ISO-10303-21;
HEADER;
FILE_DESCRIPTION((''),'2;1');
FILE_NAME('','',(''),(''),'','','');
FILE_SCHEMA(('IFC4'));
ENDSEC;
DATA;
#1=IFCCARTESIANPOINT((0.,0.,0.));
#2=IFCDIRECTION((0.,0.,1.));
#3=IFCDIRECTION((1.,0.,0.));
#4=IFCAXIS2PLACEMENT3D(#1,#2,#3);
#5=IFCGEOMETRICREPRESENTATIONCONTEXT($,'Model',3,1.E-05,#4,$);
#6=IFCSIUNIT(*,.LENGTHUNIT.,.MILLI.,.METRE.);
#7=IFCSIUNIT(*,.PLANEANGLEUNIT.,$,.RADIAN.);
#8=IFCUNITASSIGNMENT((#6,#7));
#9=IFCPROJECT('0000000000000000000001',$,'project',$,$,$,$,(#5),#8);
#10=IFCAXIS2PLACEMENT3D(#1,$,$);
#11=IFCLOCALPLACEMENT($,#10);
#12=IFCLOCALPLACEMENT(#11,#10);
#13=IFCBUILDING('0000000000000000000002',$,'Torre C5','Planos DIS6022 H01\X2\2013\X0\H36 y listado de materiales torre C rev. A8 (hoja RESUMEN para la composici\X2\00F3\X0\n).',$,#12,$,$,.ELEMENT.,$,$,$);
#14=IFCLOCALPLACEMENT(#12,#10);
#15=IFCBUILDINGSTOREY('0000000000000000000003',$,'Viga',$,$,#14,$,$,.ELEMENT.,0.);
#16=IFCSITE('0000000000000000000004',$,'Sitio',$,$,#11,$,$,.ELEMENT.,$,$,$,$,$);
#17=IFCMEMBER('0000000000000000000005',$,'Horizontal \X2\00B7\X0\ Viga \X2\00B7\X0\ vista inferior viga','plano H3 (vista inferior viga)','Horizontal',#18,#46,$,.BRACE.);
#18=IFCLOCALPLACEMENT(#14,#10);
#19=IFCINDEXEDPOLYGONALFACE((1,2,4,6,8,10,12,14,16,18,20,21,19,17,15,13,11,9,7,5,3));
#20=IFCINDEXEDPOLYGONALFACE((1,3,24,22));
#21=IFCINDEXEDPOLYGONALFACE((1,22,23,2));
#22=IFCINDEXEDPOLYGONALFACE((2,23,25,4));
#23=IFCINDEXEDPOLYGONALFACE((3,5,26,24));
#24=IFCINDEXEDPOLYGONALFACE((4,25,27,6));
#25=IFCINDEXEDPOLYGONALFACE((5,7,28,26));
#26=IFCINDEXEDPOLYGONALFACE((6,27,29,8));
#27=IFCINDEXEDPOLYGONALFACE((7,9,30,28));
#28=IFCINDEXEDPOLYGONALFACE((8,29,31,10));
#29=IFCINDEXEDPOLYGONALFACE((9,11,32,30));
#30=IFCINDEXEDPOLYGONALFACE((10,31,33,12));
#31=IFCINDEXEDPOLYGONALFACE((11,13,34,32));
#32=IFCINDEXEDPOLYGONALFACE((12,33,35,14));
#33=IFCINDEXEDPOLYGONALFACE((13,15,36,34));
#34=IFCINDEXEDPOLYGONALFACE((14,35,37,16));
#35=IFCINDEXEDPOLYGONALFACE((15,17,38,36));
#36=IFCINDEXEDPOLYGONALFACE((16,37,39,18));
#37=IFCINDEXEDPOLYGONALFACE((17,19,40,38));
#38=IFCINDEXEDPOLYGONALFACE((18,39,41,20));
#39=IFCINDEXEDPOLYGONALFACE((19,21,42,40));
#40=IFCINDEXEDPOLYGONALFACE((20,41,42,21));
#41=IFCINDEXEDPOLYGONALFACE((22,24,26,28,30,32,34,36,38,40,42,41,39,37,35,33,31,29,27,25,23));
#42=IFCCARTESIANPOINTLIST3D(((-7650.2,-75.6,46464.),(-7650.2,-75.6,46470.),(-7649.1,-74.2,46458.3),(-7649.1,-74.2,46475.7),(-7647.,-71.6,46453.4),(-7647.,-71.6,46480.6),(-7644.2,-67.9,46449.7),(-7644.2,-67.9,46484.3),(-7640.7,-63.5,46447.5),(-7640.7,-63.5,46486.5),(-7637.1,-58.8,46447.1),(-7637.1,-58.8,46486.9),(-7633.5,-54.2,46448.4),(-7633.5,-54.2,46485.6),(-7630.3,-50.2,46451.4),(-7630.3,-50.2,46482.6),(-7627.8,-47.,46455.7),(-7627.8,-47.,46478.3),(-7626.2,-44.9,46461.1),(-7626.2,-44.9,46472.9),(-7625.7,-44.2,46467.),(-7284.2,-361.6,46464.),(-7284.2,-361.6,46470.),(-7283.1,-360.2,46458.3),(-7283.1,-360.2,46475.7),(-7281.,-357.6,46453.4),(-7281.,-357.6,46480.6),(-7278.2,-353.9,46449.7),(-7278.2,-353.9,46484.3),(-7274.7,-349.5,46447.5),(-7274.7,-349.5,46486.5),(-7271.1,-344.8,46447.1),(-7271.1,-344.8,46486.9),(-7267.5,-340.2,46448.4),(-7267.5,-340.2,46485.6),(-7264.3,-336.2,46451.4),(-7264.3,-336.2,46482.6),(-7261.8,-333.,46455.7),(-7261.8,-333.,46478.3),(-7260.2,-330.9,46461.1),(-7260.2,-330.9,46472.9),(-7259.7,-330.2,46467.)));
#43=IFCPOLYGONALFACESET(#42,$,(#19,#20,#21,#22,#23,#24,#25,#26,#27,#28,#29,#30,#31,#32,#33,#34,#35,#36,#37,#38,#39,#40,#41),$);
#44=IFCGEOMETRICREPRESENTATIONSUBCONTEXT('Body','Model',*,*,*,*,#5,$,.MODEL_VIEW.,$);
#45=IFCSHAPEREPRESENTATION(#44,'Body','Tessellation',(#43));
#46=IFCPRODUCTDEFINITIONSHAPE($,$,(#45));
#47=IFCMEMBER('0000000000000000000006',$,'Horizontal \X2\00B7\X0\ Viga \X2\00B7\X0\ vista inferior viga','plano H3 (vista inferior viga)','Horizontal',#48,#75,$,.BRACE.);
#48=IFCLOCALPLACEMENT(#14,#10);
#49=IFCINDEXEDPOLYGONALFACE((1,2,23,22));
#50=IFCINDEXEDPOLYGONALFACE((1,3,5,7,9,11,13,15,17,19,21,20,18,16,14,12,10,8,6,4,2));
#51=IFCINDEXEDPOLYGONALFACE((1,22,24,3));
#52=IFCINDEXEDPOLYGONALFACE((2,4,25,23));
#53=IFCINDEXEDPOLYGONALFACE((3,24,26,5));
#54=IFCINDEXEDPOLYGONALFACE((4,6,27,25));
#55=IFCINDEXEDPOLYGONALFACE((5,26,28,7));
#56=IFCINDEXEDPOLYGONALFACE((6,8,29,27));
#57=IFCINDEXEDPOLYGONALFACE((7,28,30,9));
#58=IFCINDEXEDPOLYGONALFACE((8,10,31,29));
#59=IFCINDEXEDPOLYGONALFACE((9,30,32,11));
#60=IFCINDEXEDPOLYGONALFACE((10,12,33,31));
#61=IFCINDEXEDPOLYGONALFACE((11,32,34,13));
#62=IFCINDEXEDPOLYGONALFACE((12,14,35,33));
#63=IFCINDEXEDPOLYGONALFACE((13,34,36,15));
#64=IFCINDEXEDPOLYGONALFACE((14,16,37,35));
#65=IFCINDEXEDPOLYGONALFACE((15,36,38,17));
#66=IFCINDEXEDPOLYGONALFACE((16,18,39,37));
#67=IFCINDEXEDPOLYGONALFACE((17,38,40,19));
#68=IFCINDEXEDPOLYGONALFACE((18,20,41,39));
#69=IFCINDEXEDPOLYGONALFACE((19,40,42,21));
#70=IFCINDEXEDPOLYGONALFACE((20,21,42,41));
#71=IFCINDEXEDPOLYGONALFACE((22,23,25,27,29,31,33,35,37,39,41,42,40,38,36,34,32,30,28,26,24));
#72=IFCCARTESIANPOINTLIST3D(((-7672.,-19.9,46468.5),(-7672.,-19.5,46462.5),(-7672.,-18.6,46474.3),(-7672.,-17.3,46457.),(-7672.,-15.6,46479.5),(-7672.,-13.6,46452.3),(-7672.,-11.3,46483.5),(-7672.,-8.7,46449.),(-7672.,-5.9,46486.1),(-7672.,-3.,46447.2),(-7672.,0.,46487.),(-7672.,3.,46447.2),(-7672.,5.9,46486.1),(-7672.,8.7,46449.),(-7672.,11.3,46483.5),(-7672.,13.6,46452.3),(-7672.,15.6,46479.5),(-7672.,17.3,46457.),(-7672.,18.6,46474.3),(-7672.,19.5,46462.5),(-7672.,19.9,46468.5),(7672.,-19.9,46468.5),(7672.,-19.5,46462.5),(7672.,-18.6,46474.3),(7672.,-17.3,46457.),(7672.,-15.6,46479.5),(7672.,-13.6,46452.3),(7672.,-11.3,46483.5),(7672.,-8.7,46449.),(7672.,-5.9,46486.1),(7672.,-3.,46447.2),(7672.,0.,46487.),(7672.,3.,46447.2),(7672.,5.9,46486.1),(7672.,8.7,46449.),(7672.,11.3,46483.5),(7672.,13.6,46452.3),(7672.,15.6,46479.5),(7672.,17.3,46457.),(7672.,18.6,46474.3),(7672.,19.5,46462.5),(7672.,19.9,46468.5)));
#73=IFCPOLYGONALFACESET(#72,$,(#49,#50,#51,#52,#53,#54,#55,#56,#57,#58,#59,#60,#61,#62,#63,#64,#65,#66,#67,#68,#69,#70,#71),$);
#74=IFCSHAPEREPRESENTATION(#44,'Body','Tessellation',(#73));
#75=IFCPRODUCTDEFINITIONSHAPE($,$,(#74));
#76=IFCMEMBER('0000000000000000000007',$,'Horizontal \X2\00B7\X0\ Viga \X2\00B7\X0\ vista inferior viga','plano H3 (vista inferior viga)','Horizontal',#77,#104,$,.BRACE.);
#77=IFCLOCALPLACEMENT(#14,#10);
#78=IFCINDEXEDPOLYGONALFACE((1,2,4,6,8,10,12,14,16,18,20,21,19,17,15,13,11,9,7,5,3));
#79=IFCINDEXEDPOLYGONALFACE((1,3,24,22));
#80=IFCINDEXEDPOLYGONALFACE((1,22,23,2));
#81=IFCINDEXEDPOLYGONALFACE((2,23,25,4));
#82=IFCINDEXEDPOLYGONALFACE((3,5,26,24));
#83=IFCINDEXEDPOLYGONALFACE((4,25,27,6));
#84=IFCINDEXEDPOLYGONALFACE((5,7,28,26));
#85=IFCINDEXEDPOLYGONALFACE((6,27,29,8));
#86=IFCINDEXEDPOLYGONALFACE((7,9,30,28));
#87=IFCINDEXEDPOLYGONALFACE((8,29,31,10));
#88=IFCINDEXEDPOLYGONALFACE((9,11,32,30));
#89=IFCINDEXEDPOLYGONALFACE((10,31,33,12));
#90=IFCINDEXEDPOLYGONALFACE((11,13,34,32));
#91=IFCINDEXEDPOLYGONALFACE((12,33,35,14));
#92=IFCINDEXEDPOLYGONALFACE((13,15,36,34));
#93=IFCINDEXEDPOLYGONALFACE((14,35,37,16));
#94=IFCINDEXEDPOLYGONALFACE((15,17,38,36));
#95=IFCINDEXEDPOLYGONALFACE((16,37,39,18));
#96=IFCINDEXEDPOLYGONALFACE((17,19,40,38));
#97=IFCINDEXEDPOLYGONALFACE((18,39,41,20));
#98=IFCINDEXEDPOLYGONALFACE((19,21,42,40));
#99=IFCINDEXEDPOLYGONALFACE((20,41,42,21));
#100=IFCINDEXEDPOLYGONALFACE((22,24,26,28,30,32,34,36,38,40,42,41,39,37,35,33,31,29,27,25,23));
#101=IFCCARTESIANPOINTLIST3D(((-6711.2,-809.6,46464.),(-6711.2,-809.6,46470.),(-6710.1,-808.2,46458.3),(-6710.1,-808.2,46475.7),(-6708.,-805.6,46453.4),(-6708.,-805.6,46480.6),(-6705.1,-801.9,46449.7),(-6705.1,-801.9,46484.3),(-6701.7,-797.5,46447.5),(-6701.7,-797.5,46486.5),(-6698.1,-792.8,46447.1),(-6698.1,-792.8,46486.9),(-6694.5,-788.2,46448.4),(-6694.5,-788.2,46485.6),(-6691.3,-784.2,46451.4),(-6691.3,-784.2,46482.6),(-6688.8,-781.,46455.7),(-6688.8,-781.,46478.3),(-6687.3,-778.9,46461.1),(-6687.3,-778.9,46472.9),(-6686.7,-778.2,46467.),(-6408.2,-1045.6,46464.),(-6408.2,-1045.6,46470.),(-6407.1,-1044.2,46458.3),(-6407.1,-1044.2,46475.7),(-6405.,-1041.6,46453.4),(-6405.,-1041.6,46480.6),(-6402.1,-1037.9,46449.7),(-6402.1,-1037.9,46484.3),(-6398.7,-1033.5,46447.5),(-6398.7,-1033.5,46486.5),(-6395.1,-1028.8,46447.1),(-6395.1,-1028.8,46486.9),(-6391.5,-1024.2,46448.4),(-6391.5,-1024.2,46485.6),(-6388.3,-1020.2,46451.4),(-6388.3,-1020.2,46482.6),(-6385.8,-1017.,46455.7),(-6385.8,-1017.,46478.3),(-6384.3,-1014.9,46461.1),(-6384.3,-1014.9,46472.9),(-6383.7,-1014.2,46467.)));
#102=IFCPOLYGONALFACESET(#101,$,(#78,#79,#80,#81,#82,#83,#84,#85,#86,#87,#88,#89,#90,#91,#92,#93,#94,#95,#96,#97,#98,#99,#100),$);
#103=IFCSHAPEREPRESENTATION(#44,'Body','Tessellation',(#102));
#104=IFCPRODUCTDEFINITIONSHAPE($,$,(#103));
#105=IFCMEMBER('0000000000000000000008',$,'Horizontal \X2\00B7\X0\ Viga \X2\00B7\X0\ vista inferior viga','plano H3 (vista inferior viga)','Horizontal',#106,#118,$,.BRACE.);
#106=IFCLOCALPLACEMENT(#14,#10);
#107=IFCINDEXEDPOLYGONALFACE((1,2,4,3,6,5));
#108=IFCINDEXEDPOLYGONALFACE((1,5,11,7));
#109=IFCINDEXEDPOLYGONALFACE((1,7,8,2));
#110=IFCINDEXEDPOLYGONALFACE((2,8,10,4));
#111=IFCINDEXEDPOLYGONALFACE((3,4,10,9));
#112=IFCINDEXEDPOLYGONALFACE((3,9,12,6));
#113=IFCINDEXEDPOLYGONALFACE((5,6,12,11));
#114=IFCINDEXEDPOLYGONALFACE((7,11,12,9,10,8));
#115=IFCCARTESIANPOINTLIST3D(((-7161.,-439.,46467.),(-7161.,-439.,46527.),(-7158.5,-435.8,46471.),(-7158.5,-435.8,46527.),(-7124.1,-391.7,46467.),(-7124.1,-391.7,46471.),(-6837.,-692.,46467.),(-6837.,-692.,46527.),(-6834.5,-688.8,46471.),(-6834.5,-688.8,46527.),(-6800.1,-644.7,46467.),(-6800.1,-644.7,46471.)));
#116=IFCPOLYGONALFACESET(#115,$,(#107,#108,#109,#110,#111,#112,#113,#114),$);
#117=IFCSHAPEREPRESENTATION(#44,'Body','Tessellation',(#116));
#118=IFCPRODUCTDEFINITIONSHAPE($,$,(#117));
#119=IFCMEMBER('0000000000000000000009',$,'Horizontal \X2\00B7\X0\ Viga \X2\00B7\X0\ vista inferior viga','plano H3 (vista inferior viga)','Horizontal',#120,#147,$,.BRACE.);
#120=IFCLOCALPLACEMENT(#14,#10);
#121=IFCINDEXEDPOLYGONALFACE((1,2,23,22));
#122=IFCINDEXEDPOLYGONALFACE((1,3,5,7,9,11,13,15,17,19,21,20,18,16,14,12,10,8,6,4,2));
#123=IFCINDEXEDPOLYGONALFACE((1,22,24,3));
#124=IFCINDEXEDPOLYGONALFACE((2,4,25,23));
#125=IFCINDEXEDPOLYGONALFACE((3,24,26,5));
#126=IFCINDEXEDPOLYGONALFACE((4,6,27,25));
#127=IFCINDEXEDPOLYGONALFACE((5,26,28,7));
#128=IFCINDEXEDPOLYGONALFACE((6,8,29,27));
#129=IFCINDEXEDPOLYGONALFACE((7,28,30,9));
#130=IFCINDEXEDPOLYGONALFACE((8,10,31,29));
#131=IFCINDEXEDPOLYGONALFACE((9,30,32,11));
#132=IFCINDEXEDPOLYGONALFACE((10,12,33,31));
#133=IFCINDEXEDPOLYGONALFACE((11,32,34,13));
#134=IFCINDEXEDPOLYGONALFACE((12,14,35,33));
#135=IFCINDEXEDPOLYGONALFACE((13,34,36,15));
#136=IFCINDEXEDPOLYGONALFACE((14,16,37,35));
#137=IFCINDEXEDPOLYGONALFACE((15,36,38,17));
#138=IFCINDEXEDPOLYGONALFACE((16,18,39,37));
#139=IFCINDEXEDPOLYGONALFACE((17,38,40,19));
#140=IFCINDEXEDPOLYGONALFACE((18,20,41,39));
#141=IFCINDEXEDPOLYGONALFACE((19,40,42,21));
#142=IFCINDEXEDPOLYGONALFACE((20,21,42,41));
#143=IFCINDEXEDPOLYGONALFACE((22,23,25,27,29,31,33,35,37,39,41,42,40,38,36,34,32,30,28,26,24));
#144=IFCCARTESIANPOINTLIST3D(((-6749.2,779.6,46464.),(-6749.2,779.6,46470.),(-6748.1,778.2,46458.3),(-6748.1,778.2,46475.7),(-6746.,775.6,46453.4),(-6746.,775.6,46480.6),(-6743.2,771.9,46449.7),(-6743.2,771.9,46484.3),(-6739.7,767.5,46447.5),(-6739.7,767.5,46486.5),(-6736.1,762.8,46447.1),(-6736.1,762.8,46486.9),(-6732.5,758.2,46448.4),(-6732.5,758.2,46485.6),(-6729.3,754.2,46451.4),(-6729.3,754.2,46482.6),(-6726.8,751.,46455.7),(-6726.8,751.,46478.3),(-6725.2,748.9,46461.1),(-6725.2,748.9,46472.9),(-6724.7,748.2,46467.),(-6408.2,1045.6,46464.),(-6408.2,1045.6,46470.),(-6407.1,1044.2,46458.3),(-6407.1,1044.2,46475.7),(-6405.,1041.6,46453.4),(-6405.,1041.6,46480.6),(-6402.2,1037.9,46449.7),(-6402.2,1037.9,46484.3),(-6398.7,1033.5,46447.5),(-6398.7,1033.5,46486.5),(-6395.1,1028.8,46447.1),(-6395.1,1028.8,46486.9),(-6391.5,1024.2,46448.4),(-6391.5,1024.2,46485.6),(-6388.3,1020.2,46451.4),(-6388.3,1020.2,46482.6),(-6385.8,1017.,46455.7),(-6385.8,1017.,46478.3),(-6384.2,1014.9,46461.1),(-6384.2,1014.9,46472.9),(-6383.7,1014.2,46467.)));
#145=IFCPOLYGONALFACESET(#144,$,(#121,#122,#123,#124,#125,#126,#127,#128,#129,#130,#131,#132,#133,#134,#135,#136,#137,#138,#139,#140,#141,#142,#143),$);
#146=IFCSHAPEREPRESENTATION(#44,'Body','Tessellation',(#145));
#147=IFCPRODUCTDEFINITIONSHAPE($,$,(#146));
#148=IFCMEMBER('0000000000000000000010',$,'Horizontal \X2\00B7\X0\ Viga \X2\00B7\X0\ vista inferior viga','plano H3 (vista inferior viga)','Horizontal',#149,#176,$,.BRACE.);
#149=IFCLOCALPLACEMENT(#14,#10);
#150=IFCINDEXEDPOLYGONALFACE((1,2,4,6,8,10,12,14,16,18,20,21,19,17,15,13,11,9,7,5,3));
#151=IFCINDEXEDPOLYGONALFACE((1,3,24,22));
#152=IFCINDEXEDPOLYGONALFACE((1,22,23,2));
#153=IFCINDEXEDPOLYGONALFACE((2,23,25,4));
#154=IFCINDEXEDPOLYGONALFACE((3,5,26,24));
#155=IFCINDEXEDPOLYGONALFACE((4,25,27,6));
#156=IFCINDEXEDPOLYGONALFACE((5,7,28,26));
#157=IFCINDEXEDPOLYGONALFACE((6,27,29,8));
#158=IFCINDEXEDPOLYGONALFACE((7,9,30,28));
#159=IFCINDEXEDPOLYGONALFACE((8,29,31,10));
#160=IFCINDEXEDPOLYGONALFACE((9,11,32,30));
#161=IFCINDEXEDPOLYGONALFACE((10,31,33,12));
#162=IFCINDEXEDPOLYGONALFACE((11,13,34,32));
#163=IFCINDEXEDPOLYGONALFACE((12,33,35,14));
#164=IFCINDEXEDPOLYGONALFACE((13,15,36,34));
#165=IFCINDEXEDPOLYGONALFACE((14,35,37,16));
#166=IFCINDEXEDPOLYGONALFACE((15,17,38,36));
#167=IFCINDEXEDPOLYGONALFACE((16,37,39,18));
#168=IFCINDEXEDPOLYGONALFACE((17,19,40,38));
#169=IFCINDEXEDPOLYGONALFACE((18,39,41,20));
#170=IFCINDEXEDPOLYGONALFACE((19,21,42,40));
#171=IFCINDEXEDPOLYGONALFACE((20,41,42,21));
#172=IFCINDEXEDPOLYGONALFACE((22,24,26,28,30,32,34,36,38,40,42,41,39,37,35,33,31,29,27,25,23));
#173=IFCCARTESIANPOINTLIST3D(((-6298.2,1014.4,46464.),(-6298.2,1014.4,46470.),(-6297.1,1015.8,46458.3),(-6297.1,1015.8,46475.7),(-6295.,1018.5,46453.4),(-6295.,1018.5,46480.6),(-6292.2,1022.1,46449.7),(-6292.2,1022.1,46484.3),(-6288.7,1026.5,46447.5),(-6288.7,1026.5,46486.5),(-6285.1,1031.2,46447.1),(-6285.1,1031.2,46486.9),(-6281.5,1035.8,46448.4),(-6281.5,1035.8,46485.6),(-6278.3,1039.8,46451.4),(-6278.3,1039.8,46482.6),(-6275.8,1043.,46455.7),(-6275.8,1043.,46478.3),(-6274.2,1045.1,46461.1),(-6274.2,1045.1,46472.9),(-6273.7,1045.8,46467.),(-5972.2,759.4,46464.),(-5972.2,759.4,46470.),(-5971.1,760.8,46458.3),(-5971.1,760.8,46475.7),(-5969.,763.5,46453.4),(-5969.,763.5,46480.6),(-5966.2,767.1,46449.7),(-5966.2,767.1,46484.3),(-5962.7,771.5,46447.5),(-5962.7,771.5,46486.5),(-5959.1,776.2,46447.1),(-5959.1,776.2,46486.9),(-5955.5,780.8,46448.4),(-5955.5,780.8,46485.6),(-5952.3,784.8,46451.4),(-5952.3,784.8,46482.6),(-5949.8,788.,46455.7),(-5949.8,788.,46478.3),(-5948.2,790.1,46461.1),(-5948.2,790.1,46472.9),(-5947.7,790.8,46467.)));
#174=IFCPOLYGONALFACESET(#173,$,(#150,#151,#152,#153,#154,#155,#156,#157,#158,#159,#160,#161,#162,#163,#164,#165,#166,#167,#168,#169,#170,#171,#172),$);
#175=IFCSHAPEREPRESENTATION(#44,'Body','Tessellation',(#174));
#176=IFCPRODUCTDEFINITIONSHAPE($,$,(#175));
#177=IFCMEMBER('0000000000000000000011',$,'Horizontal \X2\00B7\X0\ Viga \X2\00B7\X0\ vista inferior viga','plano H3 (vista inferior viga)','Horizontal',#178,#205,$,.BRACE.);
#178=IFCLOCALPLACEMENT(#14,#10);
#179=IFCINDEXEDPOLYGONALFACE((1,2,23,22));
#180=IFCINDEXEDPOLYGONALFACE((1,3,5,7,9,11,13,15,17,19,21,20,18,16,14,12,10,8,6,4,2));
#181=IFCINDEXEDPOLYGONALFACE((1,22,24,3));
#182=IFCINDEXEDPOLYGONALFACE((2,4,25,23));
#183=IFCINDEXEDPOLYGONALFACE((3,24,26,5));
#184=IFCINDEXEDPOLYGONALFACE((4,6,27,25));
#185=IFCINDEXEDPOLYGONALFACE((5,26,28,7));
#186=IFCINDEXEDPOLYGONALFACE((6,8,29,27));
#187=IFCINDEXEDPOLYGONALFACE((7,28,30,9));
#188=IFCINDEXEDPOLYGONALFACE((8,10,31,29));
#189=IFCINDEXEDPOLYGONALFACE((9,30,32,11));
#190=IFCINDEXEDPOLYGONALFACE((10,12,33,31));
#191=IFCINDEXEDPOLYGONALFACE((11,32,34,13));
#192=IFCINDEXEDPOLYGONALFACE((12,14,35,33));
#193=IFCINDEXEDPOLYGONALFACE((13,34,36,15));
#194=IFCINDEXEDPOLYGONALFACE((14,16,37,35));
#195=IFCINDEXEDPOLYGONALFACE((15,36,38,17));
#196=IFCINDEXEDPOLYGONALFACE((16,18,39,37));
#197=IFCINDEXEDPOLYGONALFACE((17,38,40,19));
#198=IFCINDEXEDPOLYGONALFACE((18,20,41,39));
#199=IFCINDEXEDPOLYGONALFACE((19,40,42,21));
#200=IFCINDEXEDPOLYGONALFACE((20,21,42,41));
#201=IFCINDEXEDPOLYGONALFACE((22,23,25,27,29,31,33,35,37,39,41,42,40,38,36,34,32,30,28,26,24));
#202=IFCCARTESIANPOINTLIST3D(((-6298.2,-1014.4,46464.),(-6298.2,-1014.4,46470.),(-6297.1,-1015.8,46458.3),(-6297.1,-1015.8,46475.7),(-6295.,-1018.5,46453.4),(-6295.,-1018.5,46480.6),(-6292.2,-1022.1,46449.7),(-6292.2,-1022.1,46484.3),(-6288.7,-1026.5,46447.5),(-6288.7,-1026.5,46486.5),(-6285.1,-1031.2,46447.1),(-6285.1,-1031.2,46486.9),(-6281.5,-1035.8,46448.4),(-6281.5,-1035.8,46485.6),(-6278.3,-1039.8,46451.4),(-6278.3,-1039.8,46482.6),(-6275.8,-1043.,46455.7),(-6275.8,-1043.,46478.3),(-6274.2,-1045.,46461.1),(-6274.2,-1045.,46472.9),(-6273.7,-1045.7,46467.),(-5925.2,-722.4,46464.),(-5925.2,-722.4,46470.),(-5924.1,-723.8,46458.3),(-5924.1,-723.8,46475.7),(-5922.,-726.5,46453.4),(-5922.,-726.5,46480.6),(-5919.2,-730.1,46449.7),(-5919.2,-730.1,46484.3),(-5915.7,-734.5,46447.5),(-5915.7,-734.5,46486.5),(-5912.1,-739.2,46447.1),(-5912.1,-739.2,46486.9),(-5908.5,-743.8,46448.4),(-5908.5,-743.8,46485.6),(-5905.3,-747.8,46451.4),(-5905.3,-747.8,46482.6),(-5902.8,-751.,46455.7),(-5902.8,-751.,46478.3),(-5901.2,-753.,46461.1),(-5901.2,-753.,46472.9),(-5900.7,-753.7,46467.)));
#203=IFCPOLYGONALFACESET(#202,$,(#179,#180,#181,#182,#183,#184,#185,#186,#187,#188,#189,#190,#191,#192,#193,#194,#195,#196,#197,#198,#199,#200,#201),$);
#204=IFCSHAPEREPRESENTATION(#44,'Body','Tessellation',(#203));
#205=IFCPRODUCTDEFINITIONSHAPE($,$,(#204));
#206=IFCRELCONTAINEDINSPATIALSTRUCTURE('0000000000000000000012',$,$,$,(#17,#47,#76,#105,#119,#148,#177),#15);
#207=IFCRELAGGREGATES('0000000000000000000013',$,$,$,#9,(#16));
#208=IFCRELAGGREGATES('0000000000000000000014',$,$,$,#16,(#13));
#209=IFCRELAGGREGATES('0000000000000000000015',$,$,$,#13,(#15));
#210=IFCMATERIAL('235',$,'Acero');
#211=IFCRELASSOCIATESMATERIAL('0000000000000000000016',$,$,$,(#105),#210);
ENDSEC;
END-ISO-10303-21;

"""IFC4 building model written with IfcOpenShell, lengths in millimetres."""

from ifc_helpers import new_model, si_unit, frame, frame_2d, origin, origin_with_axes, place, context, subcontext, project, spatial, circle, l_section, extrude, material, element, save


model = new_model("IFC4")

# Units and contexts
model_context = context("Model", 3, precision=1e-05, world=origin_with_axes())
body_context = subcontext(model_context, "Body", "Model", "MODEL_VIEW")
ifc_project = project(units=[si_unit("LENGTHUNIT", "METRE", prefix="MILLI"), si_unit("PLANEANGLEUNIT", "RADIAN")], contexts=[model_context])

# Site, building, storey
site_placement = place(None, origin())
site = spatial("IfcSite", under=ifc_project, at=site_placement, Name="Sitio", CompositionType="ELEMENT")
building_placement = place(site_placement, origin())
building = spatial("IfcBuilding", under=site, at=building_placement, Name="Torre C5", Description="Planos DIS6022 H01–H36 y listado de materiales torre C rev. A8 (hoja RESUMEN para la composición).", CompositionType="ELEMENT")
storey_placement = place(building_placement, origin())
storey = spatial("IfcBuildingStorey", under=building, at=storey_placement, Name="Viga", CompositionType="ELEMENT", Elevation=0.0)

# Members
ifc_material_1 = material(Name="235", Category="Acero")
member_1_placement = place(storey_placement, frame((-7638.0, -60.0, 46467.0), z_axis=(0.787959, -0.615728, 0.0), x_axis=(0.615728, 0.787959, 0.0)))
element("IfcMember", 1, at=member_1_placement, inside=storey, Name="Horizontal · Viga · vista inferior viga", Description="plano H3 (vista inferior viga)", ObjectType="Horizontal", PredefinedType="BRACE", context=body_context, shape_type="SweptSolid", body=[
    extrude(circle(Radius=20.0), None, (0.0, 0.0, 1.0), 464.5),
])
member_2_placement = place(storey_placement, frame((-7672.0, 0.0, 46467.0), z_axis=(1.0, 0.0, 0.0), x_axis=(0.0, 0.0, 1.0)))
element("IfcMember", 2, at=member_2_placement, inside=storey, Name="Horizontal · Viga · vista inferior viga", Description="plano H3 (vista inferior viga)", ObjectType="Horizontal", PredefinedType="BRACE", context=body_context, shape_type="SweptSolid", body=[
    extrude(circle(Radius=20.0), None, (0.0, 0.0, 1.0), 15344.0),
])
member_3_placement = place(storey_placement, frame((-6699.0, -794.0, 46467.0), z_axis=(0.788931, -0.614481, 0.0), x_axis=(0.614481, 0.788931, 0.0)))
element("IfcMember", 3, at=member_3_placement, inside=storey, Name="Horizontal · Viga · vista inferior viga", Description="plano H3 (vista inferior viga)", ObjectType="Horizontal", PredefinedType="BRACE", context=body_context, shape_type="SweptSolid", body=[
    extrude(circle(Radius=20.0), None, (0.0, 0.0, 1.0), 384.1),
])
member_4_placement = place(storey_placement, frame((-7161.0, -439.0, 46467.0), z_axis=(0.788172, -0.615455, 0.0), x_axis=(0.615455, 0.788172, 0.0)))
element("IfcMember", 4, at=member_4_placement, inside=storey, material=ifc_material_1, Name="Horizontal · Viga · vista inferior viga", Description="plano H3 (vista inferior viga)", ObjectType="Horizontal", PredefinedType="BRACE", context=body_context, shape_type="SweptSolid", body=[
    extrude(l_section(Depth=60.0, Width=60.0, Thickness=4.0, at=frame_2d((30.0, 30.0))), None, (0.0, 0.0, 1.0), 411.1),
])
member_5_placement = place(storey_placement, frame((-6737.0, 764.0, 46467.0), z_axis=(0.78848, 0.615061, 0.0), x_axis=(0.615061, -0.78848, 0.0)))
element("IfcMember", 5, at=member_5_placement, inside=storey, Name="Horizontal · Viga · vista inferior viga", Description="plano H3 (vista inferior viga)", ObjectType="Horizontal", PredefinedType="BRACE", context=body_context, shape_type="SweptSolid", body=[
    extrude(circle(Radius=20.0), None, (0.0, 0.0, 1.0), 432.5),
])
member_6_placement = place(storey_placement, frame((-5960.0, 775.0, 46467.0), z_axis=(-0.787658, 0.616113, 0.0), x_axis=(0.616113, 0.787658, 0.0)))
element("IfcMember", 6, at=member_6_placement, inside=storey, Name="Horizontal · Viga · vista inferior viga", Description="plano H3 (vista inferior viga)", ObjectType="Horizontal", PredefinedType="BRACE", context=body_context, shape_type="SweptSolid", body=[
    extrude(circle(Radius=20.0), None, (0.0, 0.0, 1.0), 413.9),
])
member_7_placement = place(storey_placement, frame((-5913.0, -738.0, 46467.0), z_axis=(-0.787416, -0.616422, 0.0), x_axis=(0.616422, -0.787416, 0.0)))
element("IfcMember", 7, at=member_7_placement, inside=storey, Name="Horizontal · Viga · vista inferior viga", Description="plano H3 (vista inferior viga)", ObjectType="Horizontal", PredefinedType="BRACE", context=body_context, shape_type="SweptSolid", body=[
    extrude(circle(Radius=20.0), None, (0.0, 0.0, 1.0), 473.7),
])

save(model, "model.ifc")
